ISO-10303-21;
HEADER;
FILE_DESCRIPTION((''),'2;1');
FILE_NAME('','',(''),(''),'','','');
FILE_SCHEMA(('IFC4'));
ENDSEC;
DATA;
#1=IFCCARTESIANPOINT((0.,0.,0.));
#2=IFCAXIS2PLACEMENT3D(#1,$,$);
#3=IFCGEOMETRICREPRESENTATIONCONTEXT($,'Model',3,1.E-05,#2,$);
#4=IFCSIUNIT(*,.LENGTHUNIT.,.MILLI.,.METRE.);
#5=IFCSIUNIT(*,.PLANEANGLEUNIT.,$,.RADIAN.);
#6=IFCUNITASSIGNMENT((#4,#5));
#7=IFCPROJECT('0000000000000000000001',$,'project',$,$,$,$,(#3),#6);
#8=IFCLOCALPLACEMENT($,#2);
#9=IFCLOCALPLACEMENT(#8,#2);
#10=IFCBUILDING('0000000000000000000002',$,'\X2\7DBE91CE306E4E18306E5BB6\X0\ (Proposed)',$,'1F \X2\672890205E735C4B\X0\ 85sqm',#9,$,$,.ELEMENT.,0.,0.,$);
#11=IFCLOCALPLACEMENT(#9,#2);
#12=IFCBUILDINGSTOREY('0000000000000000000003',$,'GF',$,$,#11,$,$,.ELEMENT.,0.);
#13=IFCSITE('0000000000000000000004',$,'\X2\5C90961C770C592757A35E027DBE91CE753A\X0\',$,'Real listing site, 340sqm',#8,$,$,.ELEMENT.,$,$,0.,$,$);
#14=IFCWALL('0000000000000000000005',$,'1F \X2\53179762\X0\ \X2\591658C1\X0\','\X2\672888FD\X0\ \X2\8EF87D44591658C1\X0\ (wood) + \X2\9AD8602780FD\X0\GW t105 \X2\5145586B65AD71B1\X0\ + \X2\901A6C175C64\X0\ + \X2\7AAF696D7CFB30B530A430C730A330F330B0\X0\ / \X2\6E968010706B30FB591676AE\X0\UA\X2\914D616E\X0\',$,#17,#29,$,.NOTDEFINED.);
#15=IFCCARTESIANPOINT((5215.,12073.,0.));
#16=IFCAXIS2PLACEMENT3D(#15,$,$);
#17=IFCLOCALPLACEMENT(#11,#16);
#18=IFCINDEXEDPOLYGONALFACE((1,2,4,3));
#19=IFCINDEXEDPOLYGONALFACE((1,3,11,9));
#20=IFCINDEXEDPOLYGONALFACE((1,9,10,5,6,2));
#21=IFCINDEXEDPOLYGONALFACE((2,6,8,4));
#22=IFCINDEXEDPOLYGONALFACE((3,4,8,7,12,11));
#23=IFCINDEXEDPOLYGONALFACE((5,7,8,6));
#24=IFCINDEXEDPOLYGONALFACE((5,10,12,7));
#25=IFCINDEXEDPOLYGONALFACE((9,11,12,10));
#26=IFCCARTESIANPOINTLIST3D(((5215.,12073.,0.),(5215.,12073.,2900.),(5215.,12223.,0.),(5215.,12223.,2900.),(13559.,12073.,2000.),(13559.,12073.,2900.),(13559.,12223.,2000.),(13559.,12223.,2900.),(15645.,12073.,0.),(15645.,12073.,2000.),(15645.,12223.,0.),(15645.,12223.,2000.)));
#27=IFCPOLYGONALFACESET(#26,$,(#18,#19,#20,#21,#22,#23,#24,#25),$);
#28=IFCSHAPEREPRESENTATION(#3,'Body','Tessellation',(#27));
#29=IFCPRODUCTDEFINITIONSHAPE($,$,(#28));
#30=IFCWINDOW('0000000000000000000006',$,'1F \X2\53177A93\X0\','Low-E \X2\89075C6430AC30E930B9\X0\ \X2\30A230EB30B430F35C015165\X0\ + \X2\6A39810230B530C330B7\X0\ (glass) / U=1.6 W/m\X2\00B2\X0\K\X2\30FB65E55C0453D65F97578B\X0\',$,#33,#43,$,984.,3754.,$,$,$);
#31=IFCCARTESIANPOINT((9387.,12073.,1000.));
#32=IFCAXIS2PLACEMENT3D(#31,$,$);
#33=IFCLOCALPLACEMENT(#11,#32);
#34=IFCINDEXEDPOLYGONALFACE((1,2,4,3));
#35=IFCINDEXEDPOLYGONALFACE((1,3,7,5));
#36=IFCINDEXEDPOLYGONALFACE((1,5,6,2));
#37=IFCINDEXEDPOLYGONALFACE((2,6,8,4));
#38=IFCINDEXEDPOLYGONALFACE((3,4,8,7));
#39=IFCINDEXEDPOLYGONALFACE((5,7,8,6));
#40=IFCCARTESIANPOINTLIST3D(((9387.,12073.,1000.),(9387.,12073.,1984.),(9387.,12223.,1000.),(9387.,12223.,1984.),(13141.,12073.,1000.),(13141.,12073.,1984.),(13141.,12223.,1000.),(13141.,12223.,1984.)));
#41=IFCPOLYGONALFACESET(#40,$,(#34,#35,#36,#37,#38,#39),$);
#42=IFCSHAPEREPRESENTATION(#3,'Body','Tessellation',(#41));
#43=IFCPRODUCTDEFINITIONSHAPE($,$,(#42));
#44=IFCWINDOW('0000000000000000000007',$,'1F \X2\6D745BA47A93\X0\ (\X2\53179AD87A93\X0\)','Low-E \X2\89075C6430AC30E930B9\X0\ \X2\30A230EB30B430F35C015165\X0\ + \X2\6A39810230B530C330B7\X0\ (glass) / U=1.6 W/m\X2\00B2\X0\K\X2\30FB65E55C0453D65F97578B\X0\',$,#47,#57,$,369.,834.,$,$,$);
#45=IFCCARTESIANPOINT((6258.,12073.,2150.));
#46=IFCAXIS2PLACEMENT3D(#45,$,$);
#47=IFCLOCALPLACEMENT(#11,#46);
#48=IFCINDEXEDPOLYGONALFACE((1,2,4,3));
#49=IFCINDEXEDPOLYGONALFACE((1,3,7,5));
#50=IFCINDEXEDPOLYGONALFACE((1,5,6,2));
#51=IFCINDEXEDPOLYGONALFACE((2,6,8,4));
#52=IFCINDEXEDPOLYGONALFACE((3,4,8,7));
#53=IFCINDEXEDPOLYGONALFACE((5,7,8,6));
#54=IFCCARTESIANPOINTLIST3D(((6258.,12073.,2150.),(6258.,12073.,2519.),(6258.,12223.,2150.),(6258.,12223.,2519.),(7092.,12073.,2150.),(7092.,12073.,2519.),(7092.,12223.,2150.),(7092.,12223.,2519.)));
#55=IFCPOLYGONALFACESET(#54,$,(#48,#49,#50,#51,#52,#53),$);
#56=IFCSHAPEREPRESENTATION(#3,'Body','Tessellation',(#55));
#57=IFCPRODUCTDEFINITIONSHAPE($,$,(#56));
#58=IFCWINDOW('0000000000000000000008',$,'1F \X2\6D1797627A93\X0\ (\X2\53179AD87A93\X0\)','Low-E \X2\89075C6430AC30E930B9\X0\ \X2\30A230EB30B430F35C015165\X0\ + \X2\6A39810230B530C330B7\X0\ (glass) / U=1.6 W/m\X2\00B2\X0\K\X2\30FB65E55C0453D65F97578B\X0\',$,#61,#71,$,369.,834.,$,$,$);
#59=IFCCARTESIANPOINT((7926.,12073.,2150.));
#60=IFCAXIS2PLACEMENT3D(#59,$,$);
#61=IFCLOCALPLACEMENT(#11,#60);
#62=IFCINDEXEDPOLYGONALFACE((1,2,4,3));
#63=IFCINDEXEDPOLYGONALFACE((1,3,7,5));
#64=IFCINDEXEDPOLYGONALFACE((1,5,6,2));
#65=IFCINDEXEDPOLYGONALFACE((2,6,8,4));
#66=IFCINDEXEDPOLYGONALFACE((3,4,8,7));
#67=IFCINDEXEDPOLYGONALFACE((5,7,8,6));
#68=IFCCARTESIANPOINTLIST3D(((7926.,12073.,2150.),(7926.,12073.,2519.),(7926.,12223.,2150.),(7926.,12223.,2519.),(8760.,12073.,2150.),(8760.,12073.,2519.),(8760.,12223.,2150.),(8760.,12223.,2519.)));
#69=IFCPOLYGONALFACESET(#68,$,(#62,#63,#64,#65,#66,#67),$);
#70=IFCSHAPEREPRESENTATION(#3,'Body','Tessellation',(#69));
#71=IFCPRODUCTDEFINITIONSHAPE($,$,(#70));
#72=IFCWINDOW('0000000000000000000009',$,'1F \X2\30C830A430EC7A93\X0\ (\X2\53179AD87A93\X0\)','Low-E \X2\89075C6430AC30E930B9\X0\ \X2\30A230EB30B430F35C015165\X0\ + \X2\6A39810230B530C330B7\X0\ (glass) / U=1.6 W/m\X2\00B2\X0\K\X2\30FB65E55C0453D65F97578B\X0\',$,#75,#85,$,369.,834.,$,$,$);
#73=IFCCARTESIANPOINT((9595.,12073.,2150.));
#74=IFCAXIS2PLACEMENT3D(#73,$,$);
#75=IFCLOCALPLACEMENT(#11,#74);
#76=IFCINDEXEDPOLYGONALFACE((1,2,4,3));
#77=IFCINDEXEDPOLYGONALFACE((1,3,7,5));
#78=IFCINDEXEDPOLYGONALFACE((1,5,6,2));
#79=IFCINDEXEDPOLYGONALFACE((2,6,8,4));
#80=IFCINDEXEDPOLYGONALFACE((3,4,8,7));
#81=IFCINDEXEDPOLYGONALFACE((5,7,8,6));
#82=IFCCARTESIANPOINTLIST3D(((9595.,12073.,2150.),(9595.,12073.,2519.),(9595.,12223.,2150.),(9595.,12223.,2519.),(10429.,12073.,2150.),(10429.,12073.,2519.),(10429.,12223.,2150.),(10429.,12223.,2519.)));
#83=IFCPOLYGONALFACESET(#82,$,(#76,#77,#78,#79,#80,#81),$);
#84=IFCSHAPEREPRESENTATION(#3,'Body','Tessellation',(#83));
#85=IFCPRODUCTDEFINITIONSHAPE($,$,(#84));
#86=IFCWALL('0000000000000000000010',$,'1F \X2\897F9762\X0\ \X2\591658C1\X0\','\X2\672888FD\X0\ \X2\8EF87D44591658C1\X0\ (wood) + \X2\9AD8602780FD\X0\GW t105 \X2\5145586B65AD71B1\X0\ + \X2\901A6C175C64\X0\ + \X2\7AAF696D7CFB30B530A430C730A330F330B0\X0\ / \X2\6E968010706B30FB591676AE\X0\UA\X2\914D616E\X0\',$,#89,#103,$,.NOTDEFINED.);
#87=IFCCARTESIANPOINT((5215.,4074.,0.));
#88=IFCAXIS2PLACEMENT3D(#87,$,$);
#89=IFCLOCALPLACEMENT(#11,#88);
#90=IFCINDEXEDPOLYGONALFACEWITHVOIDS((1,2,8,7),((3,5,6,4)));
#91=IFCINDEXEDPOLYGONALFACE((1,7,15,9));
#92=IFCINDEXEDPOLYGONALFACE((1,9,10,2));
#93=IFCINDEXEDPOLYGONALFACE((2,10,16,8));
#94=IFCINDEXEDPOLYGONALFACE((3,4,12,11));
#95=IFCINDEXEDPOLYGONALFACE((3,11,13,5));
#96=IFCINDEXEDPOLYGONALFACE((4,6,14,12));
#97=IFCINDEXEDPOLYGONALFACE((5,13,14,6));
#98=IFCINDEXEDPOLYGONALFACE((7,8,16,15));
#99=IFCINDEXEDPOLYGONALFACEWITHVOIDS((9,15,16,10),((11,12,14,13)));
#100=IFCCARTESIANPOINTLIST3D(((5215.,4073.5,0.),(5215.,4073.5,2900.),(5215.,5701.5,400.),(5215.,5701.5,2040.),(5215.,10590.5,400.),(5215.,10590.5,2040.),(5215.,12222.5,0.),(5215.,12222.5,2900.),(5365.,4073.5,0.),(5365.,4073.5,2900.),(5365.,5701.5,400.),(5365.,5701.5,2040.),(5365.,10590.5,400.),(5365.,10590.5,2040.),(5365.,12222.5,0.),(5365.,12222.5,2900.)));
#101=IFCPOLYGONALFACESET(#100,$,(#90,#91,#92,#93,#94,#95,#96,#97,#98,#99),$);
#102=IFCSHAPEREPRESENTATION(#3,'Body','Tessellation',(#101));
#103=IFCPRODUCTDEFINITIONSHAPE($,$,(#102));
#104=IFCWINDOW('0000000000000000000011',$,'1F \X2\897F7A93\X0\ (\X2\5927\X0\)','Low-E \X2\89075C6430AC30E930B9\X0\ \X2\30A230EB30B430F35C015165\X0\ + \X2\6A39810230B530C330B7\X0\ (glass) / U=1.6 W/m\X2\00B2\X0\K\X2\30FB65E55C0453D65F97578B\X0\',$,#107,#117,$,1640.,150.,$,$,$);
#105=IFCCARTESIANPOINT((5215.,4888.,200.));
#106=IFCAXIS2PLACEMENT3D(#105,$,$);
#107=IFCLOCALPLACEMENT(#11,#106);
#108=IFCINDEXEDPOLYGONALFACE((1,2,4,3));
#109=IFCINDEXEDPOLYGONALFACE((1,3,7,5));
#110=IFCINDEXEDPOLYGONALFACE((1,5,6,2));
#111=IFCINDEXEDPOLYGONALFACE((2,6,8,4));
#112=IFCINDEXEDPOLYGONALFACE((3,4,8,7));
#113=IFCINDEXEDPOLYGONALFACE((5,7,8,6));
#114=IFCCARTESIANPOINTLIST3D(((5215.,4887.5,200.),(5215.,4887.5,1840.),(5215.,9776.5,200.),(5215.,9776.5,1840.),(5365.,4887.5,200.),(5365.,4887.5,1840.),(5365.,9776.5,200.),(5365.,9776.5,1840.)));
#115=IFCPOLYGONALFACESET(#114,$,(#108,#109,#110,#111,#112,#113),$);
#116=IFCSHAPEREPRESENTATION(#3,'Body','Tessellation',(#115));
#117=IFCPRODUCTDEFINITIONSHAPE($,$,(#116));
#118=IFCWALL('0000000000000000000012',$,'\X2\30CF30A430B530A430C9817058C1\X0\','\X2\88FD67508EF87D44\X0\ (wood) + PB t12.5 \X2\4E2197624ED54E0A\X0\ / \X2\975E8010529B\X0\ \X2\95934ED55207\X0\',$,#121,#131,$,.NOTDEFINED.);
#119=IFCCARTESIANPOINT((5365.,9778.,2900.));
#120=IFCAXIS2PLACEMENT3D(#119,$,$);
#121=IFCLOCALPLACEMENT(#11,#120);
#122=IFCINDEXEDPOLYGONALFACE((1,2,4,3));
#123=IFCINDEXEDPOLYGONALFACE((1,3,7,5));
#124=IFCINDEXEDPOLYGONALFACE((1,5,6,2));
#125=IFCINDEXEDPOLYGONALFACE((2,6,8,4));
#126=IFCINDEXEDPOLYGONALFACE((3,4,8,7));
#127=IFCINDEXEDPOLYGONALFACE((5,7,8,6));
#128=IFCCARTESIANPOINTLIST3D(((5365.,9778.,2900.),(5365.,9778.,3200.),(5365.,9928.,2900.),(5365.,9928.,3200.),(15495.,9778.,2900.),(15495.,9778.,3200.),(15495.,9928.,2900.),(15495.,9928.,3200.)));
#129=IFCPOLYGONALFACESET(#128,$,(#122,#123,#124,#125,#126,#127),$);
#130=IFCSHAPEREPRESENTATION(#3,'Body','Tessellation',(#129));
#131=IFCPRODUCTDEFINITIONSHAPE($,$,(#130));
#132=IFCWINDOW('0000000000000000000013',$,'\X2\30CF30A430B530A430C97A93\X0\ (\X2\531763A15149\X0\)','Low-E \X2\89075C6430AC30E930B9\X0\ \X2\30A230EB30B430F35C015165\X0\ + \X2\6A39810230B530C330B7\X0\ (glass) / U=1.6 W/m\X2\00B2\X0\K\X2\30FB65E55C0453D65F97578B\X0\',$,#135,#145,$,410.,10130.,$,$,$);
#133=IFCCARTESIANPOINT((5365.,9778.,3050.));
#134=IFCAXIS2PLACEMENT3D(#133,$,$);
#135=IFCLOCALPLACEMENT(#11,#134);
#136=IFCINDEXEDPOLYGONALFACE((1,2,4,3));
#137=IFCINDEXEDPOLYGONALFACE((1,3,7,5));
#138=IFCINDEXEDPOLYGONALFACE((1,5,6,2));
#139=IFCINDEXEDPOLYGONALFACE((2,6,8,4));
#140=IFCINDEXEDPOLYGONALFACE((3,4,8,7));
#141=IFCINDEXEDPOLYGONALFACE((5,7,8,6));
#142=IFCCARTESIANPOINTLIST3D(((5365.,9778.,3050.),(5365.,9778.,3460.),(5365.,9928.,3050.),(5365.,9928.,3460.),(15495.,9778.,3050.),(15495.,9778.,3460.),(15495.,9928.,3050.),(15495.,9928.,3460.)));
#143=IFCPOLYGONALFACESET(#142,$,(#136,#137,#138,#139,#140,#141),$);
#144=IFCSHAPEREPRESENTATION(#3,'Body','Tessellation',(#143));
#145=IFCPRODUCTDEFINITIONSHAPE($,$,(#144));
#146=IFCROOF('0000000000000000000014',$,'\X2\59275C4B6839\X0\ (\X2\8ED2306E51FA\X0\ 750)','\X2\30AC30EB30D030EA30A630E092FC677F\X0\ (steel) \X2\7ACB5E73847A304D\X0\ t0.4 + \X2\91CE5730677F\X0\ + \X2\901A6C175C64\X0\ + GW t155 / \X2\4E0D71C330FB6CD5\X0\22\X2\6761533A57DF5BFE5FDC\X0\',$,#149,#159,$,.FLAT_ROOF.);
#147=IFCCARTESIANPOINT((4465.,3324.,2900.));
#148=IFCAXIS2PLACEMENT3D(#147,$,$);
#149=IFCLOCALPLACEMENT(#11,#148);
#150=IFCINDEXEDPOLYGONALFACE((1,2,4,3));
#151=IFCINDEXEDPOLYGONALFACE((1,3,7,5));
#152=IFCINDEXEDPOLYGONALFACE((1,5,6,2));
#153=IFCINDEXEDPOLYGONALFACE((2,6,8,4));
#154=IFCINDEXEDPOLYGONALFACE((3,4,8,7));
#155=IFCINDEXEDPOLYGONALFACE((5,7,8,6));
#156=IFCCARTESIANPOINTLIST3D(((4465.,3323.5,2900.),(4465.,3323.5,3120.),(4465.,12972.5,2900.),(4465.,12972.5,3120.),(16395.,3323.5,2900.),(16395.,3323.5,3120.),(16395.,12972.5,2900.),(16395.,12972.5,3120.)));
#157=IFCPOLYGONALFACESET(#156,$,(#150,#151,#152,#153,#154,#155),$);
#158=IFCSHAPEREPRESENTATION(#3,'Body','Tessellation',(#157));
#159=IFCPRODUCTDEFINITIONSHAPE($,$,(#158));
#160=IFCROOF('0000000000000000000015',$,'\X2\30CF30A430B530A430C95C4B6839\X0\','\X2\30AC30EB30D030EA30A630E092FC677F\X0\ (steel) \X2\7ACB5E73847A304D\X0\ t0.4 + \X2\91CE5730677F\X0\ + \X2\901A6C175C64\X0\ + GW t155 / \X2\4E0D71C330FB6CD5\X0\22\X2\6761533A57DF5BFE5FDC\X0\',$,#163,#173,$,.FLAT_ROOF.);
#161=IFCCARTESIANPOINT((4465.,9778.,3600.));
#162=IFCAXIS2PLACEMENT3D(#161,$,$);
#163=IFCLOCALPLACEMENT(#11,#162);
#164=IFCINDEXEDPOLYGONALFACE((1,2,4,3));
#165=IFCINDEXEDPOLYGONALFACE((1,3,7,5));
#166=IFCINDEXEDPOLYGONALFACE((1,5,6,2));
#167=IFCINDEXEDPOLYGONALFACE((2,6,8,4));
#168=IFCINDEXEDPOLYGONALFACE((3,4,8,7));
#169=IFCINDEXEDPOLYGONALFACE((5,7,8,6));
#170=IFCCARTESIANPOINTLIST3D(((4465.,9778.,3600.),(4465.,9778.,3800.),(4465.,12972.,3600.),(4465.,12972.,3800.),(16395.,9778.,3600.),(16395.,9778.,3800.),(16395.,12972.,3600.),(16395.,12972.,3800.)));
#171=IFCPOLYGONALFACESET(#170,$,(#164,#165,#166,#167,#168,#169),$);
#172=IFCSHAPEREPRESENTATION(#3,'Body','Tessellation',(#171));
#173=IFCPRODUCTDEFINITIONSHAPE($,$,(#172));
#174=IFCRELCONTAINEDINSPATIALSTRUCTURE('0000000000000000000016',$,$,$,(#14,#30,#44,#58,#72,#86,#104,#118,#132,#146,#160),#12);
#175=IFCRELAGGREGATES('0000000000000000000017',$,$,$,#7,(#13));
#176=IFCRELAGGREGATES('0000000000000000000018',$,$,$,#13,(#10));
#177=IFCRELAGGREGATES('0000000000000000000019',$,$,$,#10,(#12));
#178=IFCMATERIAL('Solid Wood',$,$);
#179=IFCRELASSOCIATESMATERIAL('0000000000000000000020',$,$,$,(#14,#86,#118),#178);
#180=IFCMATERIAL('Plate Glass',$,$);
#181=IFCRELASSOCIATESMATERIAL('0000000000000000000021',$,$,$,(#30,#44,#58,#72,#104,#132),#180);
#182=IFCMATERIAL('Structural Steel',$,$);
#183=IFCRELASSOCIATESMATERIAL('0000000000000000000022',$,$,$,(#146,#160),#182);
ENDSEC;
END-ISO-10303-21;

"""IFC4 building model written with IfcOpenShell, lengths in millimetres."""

from ifc_helpers import new_model, si_unit, frame, frame_2d, origin, place, context, project, spatial, rectangle, extrude, material, element, fill, save


model = new_model("IFC4")

# Units and contexts
model_context = context("Model", 3, precision=1e-05, world=origin())
ifc_project = project(units=[si_unit("LENGTHUNIT", "METRE", prefix="MILLI"), si_unit("PLANEANGLEUNIT", "RADIAN")], contexts=[model_context])

# Site, building, storey
site_placement = place(None, origin())
site = spatial("IfcSite", under=ifc_project, at=site_placement, Name="岐阜県大垣市綾野町", ObjectType="Real listing site, 340sqm", CompositionType="ELEMENT", RefElevation=0.0)
building_placement = place(site_placement, origin())
building = spatial("IfcBuilding", under=site, at=building_placement, Name="綾野の丘の家 (Proposed)", ObjectType="1F 木造平屋 85sqm", CompositionType="ELEMENT", ElevationOfRefHeight=0.0, ElevationOfTerrain=0.0)
storey_placement = place(building_placement, origin())
storey = spatial("IfcBuildingStorey", under=building, at=storey_placement, Name="GF", CompositionType="ELEMENT", Elevation=0.0)

# Shared definitions
ifc_material_1 = material(Name="Solid Wood")

# Shared definitions
ifc_material_2 = material(Name="Plate Glass")

# Wall, openings, windows
wall_1_placement = place(storey_placement, frame((5215.0, 12073.0, 0.0)))
wall_1 = element("IfcWall", 1, at=wall_1_placement, inside=storey, material=ifc_material_1, Name="1F 北面 外壁", Description="木製 軸組外壁 (wood) + 高性能GW t105 充填断熱 + 通気層 + 窯業系サイディング / 準耐火・外皮UA配慮", PredefinedType="NOTDEFINED", context=model_context, shape_type="SweptSolid", body=[
    extrude(rectangle(XDim=10430.0, YDim=150.0, at=frame_2d((5215.0, 75.0))), frame((5215.0, 12073.0, 0.0)), (0.0, 0.0, 1.0), 2900.0),
])
opening_1_placement = place(storey_placement, frame((9387.0, 12073.0, 1000.0)))
opening_1 = element("IfcOpeningElement", 2, at=opening_1_placement, cuts=wall_1, PredefinedType="NOTDEFINED", context=model_context, shape_type="SweptSolid", body=[
    extrude(rectangle(XDim=3754.0, YDim=150.0, at=frame_2d((1877.0, 75.0))), frame((9387.0, 12073.0, 1000.0)), (0.0, 0.0, 1.0), 984.0),
])
opening_2_placement = place(storey_placement, frame((6258.0, 12073.0, 2150.0)))
opening_2 = element("IfcOpeningElement", 3, at=opening_2_placement, cuts=wall_1, PredefinedType="NOTDEFINED", context=model_context, shape_type="SweptSolid", body=[
    extrude(rectangle(XDim=834.0, YDim=150.0, at=frame_2d((417.0, 75.0))), frame((6258.0, 12073.0, 2150.0)), (0.0, 0.0, 1.0), 369.0),
])
opening_3_placement = place(storey_placement, frame((7926.0, 12073.0, 2150.0)))
opening_3 = element("IfcOpeningElement", 4, at=opening_3_placement, cuts=wall_1, PredefinedType="NOTDEFINED", context=model_context, shape_type="SweptSolid", body=[
    extrude(rectangle(XDim=834.0, YDim=150.0, at=frame_2d((417.0, 75.0))), frame((7926.0, 12073.0, 2150.0)), (0.0, 0.0, 1.0), 369.0),
])
opening_4_placement = place(storey_placement, frame((9595.0, 12073.0, 2150.0)))
opening_4 = element("IfcOpeningElement", 5, at=opening_4_placement, cuts=wall_1, PredefinedType="NOTDEFINED", context=model_context, shape_type="SweptSolid", body=[
    extrude(rectangle(XDim=834.0, YDim=150.0, at=frame_2d((417.0, 75.0))), frame((9595.0, 12073.0, 2150.0)), (0.0, 0.0, 1.0), 369.0),
])
window_1_placement = place(storey_placement, frame((9387.0, 12073.0, 1000.0)))
window_1 = element("IfcWindow", 6, at=window_1_placement, inside=storey, material=ifc_material_2, Name="1F 北窓", Description="Low-E 複層ガラス アルゴン封入 + 樹脂サッシ (glass) / U=1.6 W/m²K・日射取得型", OverallHeight=984.0, OverallWidth=3754.0, context=model_context, shape_type="SweptSolid", body=[
    extrude(rectangle(XDim=3754.0, YDim=150.0, at=frame_2d((1877.0, 75.0))), frame((9387.0, 12073.0, 1000.0)), (0.0, 0.0, 1.0), 984.0),
])
fill(opening_1, window_1)
window_2_placement = place(storey_placement, frame((6258.0, 12073.0, 2150.0)))
window_2 = element("IfcWindow", 7, at=window_2_placement, inside=storey, material=ifc_material_2, Name="1F 浴室窓 (北高窓)", Description="Low-E 複層ガラス アルゴン封入 + 樹脂サッシ (glass) / U=1.6 W/m²K・日射取得型", OverallHeight=369.0, OverallWidth=834.0, context=model_context, shape_type="SweptSolid", body=[
    extrude(rectangle(XDim=834.0, YDim=150.0, at=frame_2d((417.0, 75.0))), frame((6258.0, 12073.0, 2150.0)), (0.0, 0.0, 1.0), 369.0),
])
fill(opening_2, window_2)
window_3_placement = place(storey_placement, frame((7926.0, 12073.0, 2150.0)))
window_3 = element("IfcWindow", 8, at=window_3_placement, inside=storey, material=ifc_material_2, Name="1F 洗面窓 (北高窓)", Description="Low-E 複層ガラス アルゴン封入 + 樹脂サッシ (glass) / U=1.6 W/m²K・日射取得型", OverallHeight=369.0, OverallWidth=834.0, context=model_context, shape_type="SweptSolid", body=[
    extrude(rectangle(XDim=834.0, YDim=150.0, at=frame_2d((417.0, 75.0))), frame((7926.0, 12073.0, 2150.0)), (0.0, 0.0, 1.0), 369.0),
])
fill(opening_3, window_3)
window_4_placement = place(storey_placement, frame((9595.0, 12073.0, 2150.0)))
window_4 = element("IfcWindow", 9, at=window_4_placement, inside=storey, material=ifc_material_2, Name="1F トイレ窓 (北高窓)", Description="Low-E 複層ガラス アルゴン封入 + 樹脂サッシ (glass) / U=1.6 W/m²K・日射取得型", OverallHeight=369.0, OverallWidth=834.0, context=model_context, shape_type="SweptSolid", body=[
    extrude(rectangle(XDim=834.0, YDim=150.0, at=frame_2d((417.0, 75.0))), frame((9595.0, 12073.0, 2150.0)), (0.0, 0.0, 1.0), 369.0),
])
fill(opening_4, window_4)

# Wall, opening, window
wall_2_placement = place(storey_placement, frame((5215.0, 4074.0, 0.0)))
wall_2 = element("IfcWall", 10, at=wall_2_placement, inside=storey, material=ifc_material_1, Name="1F 西面 外壁", Description="木製 軸組外壁 (wood) + 高性能GW t105 充填断熱 + 通気層 + 窯業系サイディング / 準耐火・外皮UA配慮", PredefinedType="NOTDEFINED", context=model_context, shape_type="SweptSolid", body=[
    extrude(rectangle(XDim=150.0, YDim=8149.0, at=frame_2d((75.0, 4074.0))), frame((5215.0, 4074.0, 0.0)), (0.0, 0.0, 1.0), 2900.0),
])
opening_5_placement = place(storey_placement, frame((5215.0, 4888.0, 200.0)))
opening_5 = element("IfcOpeningElement", 11, at=opening_5_placement, cuts=wall_2, PredefinedType="NOTDEFINED", context=model_context, shape_type="SweptSolid", body=[
    extrude(rectangle(XDim=150.0, YDim=4889.0, at=frame_2d((75.0, 2444.0))), frame((5215.0, 4888.0, 200.0)), (0.0, 0.0, 1.0), 1640.0),
])
window_5_placement = place(storey_placement, frame((5215.0, 4888.0, 200.0)))
window_5 = element("IfcWindow", 12, at=window_5_placement, inside=storey, material=ifc_material_2, Name="1F 西窓 (大)", Description="Low-E 複層ガラス アルゴン封入 + 樹脂サッシ (glass) / U=1.6 W/m²K・日射取得型", OverallHeight=1640.0, OverallWidth=150.0, context=model_context, shape_type="SweptSolid", body=[
    extrude(rectangle(XDim=150.0, YDim=4889.0, at=frame_2d((75.0, 2444.0))), frame((5215.0, 4888.0, 200.0)), (0.0, 0.0, 1.0), 1640.0),
])
fill(opening_5, window_5)

# Wall, opening, window
wall_3_placement = place(storey_placement, frame((5365.0, 9778.0, 2900.0)))
wall_3 = element("IfcWall", 13, at=wall_3_placement, inside=storey, material=ifc_material_1, Name="ハイサイド腰壁", Description="製材軸組 (wood) + PB t12.5 両面仕上 / 非耐力 間仕切", PredefinedType="NOTDEFINED", context=model_context, shape_type="SweptSolid", body=[
    extrude(rectangle(XDim=10130.0, YDim=150.0, at=frame_2d((5065.0, 75.0))), frame((5365.0, 9778.0, 2900.0)), (0.0, 0.0, 1.0), 700.0),
])
opening_6_placement = place(storey_placement, frame((5365.0, 9778.0, 3050.0)))
opening_6 = element("IfcOpeningElement", 14, at=opening_6_placement, cuts=wall_3, PredefinedType="NOTDEFINED", context=model_context, shape_type="SweptSolid", body=[
    extrude(rectangle(XDim=10130.0, YDim=150.0, at=frame_2d((5065.0, 75.0))), frame((5365.0, 9778.0, 3050.0)), (0.0, 0.0, 1.0), 410.0),
])
window_6_placement = place(storey_placement, frame((5365.0, 9778.0, 3050.0)))
window_6 = element("IfcWindow", 15, at=window_6_placement, inside=storey, material=ifc_material_2, Name="ハイサイド窓 (北採光)", Description="Low-E 複層ガラス アルゴン封入 + 樹脂サッシ (glass) / U=1.6 W/m²K・日射取得型", OverallHeight=410.0, OverallWidth=10130.0, context=model_context, shape_type="SweptSolid", body=[
    extrude(rectangle(XDim=10130.0, YDim=150.0, at=frame_2d((5065.0, 75.0))), frame((5365.0, 9778.0, 3050.0)), (0.0, 0.0, 1.0), 410.0),
])
fill(opening_6, window_6)

# Roofs
ifc_material_3 = material(Name="Structural Steel")
roof_1_placement = place(storey_placement, frame((4465.0, 3324.0, 2900.0)))
element("IfcRoof", 16, at=roof_1_placement, inside=storey, material=ifc_material_3, Name="大屋根 (軒の出 750)", Description="ガルバリウム鋼板 (steel) 立平葺き t0.4 + 野地板 + 通気層 + GW t155 / 不燃・法22条区域対応", PredefinedType="FLAT_ROOF", context=model_context, shape_type="SweptSolid", body=[
    extrude(rectangle(XDim=11930.0, YDim=9649.0, at=frame_2d((5965.0, 4824.0))), frame((4465.0, 3324.0, 2900.0)), (0.0, 0.0, 1.0), 220.0),
])
roof_2_placement = place(storey_placement, frame((4465.0, 9778.0, 3600.0)))
element("IfcRoof", 17, at=roof_2_placement, inside=storey, material=ifc_material_3, Name="ハイサイド屋根", Description="ガルバリウム鋼板 (steel) 立平葺き t0.4 + 野地板 + 通気層 + GW t155 / 不燃・法22条区域対応", PredefinedType="FLAT_ROOF", context=model_context, shape_type="SweptSolid", body=[
    extrude(rectangle(XDim=11930.0, YDim=3194.0, at=frame_2d((5965.0, 1597.0))), frame((4465.0, 9778.0, 3600.0)), (0.0, 0.0, 1.0), 200.0),
])

save(model, "model.ifc")
